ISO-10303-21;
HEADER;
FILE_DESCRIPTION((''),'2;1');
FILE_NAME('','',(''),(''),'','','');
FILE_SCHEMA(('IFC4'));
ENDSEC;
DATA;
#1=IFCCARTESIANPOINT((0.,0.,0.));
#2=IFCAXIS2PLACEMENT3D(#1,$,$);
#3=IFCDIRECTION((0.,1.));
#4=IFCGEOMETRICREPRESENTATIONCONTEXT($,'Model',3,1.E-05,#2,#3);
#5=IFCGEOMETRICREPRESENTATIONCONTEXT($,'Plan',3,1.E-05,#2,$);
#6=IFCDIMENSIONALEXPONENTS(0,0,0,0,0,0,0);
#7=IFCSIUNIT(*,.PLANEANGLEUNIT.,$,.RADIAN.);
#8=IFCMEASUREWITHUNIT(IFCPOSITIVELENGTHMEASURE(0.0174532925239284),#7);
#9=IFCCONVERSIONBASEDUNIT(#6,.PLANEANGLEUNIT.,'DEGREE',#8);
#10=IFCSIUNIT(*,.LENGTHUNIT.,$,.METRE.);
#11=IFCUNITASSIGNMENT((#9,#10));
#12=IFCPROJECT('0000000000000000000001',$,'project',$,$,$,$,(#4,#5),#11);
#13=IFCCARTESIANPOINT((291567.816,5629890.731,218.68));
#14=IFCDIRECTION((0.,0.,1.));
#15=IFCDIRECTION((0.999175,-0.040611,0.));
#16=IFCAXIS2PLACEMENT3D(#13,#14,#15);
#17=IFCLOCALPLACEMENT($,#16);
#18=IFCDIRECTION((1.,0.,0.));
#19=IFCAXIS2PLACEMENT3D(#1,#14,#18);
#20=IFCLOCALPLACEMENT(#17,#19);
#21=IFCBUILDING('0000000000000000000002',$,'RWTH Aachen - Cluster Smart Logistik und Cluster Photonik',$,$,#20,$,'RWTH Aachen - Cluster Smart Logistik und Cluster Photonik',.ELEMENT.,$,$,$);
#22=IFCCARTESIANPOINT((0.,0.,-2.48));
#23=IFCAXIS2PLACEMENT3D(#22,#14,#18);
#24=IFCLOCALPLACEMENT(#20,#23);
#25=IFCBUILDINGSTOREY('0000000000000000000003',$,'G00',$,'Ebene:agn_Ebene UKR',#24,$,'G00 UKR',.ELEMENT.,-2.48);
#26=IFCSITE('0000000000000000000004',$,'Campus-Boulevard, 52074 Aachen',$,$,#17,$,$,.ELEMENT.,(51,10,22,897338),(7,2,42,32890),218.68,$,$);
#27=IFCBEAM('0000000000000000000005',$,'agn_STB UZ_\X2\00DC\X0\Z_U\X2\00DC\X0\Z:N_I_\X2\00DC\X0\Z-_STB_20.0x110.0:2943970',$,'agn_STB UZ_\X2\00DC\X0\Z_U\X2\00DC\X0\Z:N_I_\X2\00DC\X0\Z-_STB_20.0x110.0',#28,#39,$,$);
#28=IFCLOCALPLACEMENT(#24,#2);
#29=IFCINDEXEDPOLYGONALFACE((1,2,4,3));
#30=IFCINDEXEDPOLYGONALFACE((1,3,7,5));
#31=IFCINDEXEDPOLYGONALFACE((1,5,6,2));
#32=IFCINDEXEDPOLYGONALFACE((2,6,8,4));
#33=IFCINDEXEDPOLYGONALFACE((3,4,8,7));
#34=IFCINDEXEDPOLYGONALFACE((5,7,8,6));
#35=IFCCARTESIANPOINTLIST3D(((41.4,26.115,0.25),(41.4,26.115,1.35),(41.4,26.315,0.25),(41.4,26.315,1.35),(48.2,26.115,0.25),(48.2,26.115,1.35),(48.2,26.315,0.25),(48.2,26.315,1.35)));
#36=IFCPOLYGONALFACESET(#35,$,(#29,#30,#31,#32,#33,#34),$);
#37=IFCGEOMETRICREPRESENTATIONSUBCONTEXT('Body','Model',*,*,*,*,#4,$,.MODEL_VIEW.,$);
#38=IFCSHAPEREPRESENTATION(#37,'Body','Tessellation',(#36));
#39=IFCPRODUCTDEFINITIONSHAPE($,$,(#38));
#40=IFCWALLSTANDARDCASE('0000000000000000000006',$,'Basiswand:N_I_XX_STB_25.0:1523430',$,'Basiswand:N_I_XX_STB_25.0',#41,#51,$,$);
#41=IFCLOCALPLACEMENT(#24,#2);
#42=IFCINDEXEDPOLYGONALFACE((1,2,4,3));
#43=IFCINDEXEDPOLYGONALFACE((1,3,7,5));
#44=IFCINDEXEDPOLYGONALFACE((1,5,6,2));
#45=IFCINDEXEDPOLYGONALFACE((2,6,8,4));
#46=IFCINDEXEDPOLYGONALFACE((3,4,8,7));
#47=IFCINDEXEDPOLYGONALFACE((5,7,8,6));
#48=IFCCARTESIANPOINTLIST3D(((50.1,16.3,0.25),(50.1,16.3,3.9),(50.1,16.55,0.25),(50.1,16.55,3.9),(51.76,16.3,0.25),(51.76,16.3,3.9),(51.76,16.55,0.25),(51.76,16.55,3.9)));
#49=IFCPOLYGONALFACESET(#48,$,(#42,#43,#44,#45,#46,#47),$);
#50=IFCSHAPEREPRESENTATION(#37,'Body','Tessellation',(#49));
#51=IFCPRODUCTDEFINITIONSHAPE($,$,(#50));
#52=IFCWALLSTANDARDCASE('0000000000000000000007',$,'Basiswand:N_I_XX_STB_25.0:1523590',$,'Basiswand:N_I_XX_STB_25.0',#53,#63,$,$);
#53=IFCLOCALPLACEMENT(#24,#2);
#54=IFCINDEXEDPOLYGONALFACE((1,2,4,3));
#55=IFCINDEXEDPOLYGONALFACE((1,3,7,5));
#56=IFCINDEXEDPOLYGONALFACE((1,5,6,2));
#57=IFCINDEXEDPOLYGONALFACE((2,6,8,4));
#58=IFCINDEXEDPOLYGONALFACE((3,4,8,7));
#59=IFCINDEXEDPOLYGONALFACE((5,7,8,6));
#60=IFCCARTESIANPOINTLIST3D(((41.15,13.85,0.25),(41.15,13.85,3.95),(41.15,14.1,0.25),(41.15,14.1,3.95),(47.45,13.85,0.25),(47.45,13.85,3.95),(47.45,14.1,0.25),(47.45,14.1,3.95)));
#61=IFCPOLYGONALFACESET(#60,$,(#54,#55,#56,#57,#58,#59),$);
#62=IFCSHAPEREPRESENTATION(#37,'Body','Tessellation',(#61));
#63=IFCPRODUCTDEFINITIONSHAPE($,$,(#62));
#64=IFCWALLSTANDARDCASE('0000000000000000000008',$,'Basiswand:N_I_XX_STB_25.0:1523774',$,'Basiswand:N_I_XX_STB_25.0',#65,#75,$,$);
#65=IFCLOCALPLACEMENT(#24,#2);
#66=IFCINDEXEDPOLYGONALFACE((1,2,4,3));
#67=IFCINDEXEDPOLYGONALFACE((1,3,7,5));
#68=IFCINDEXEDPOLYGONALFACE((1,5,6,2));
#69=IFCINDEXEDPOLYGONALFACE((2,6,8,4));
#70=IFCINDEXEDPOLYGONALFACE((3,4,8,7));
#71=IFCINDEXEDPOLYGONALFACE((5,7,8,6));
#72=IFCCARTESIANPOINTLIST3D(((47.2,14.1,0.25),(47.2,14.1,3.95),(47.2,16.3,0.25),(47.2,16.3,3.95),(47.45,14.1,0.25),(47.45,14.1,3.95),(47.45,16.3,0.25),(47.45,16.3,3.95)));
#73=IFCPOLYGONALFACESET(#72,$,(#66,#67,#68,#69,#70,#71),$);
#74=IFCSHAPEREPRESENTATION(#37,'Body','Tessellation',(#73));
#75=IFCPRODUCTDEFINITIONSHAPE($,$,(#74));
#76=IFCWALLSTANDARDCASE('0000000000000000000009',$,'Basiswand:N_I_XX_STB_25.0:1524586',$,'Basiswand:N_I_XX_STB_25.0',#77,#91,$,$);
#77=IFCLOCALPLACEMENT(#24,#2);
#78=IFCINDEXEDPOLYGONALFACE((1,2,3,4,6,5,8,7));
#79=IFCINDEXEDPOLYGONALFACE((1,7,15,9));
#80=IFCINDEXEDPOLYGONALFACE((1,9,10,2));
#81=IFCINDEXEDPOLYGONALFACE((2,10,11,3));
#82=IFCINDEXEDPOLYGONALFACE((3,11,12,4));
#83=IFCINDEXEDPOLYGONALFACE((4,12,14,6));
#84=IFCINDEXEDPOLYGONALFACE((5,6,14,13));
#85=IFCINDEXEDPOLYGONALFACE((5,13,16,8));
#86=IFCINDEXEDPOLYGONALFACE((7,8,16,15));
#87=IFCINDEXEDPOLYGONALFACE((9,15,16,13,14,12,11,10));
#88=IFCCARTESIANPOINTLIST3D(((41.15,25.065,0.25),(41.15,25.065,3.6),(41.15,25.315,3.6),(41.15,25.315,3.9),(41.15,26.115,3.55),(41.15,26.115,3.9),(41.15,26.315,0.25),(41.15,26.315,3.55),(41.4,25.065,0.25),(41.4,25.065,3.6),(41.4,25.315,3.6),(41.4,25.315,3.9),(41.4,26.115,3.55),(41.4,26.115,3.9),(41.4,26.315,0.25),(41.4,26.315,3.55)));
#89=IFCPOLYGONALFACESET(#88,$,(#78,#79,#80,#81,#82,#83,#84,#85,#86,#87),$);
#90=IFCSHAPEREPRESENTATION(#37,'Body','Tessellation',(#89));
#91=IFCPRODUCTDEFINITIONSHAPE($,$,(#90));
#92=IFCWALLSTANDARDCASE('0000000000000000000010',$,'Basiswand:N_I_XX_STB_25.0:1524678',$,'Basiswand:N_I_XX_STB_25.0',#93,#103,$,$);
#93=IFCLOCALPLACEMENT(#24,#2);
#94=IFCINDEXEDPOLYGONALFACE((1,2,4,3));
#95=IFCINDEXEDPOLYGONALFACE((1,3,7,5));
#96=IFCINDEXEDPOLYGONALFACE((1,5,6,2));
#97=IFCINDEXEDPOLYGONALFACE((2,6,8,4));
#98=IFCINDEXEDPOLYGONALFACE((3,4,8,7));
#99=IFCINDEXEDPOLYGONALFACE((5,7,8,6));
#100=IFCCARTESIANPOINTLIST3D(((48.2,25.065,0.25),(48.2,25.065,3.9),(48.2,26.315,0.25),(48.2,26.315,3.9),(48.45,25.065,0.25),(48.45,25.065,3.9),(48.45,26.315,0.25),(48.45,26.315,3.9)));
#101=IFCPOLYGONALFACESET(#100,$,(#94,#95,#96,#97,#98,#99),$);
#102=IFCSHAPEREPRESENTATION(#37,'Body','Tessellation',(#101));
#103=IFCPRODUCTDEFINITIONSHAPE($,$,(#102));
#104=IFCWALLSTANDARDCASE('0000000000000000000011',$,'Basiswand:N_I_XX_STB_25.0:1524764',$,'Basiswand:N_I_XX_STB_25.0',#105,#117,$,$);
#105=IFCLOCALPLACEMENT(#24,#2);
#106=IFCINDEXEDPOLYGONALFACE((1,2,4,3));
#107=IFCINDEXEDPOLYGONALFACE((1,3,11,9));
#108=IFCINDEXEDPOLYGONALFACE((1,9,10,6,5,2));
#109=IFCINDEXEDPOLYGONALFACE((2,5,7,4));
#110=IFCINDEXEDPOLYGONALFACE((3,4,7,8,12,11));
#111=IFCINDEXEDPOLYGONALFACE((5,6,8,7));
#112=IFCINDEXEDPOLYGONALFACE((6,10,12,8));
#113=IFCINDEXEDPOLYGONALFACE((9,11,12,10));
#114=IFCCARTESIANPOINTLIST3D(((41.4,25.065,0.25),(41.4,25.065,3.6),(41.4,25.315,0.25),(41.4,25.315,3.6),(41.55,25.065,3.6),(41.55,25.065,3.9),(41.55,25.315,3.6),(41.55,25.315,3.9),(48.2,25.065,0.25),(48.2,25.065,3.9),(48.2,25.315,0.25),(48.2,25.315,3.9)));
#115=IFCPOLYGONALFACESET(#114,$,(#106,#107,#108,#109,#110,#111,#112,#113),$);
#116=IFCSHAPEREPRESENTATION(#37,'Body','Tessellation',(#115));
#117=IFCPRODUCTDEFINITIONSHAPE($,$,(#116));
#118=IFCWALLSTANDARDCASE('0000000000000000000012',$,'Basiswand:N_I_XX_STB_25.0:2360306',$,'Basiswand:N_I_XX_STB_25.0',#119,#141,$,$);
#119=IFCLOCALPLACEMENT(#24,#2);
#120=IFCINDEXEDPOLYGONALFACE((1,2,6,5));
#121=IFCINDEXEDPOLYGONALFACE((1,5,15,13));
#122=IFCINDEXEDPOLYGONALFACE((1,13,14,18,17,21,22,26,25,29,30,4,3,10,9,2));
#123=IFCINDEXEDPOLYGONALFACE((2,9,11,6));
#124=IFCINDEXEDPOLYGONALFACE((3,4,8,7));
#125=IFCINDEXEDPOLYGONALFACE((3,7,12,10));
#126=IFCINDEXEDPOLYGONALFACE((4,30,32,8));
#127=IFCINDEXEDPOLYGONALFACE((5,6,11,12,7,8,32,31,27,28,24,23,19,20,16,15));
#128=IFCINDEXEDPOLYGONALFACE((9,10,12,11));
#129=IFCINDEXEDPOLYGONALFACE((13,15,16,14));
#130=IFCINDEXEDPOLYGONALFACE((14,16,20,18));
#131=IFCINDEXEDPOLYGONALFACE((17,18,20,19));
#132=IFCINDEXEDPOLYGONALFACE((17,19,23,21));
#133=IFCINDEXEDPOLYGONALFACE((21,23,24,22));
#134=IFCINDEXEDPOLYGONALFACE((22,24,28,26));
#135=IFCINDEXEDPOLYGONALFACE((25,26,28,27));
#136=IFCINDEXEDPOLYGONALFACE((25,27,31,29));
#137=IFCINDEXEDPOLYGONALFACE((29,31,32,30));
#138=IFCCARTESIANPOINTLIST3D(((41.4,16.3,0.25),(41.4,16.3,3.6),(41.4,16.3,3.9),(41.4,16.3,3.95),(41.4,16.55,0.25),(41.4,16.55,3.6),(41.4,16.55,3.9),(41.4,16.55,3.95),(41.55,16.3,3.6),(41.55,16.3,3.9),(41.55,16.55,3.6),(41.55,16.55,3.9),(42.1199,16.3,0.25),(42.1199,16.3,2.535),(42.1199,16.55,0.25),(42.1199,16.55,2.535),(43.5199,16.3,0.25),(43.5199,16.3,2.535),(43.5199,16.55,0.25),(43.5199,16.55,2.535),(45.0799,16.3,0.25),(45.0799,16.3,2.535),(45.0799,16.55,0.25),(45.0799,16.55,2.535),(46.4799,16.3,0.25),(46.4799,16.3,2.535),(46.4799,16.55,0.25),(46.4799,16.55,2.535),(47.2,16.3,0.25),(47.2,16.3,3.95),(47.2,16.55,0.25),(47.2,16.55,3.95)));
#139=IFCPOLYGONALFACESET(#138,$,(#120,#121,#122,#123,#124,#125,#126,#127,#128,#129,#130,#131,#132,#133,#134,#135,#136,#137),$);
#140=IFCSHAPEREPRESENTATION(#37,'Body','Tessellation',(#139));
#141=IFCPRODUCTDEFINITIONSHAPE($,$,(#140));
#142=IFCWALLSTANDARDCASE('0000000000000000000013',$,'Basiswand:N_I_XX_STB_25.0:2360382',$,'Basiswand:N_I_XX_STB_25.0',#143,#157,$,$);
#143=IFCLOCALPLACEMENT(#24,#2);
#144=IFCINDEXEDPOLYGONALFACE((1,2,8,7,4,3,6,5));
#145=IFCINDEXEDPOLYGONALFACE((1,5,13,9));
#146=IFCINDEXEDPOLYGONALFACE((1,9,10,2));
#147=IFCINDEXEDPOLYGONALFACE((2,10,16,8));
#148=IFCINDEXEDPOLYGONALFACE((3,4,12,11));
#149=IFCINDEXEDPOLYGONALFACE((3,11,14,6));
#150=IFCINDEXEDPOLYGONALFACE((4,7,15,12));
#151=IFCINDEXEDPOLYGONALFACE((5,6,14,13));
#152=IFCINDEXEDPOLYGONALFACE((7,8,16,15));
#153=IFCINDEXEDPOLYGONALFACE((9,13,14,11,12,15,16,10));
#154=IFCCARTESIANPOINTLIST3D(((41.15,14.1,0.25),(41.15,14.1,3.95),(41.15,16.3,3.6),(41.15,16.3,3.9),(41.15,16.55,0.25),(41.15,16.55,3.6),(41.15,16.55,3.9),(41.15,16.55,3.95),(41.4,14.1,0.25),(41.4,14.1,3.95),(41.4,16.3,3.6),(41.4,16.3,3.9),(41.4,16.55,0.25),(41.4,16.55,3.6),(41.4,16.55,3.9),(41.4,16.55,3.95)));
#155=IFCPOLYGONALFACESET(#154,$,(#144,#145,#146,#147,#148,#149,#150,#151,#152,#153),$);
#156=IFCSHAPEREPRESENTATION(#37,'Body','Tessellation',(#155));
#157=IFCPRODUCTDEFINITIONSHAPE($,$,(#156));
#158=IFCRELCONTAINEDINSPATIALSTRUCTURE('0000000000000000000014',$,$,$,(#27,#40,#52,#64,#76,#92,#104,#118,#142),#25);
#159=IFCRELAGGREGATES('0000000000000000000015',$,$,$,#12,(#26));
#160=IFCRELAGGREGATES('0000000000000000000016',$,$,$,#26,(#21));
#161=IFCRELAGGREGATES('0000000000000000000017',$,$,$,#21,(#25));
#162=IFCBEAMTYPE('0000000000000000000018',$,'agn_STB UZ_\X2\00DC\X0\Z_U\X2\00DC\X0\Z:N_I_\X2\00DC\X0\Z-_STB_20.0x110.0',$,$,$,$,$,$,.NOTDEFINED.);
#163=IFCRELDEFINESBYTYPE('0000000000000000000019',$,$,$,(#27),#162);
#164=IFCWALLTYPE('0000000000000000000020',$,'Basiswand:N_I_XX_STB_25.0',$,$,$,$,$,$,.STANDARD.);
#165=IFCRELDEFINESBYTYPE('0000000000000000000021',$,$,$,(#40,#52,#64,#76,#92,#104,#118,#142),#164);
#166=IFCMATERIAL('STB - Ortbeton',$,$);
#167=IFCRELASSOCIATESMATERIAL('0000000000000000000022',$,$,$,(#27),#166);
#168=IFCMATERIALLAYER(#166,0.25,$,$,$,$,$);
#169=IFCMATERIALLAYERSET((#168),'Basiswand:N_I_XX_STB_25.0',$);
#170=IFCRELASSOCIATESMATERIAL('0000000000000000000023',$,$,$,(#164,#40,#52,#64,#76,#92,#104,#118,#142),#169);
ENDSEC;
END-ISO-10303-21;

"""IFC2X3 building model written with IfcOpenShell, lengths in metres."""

from ifc_helpers import new_model, entity, si_unit, converted_unit, direction, frame, frame_2d, origin, origin_with_axes, place, context, subcontext, project, spatial, polyline, rectangle, extrude, clip, bounded_halfspace, material, layer, layer_set, layer_usage, type_object, element, save


model = new_model("IFC2X3")

# Units and contexts
model_context = context("Model", 3, precision=1e-05, world=origin(), true_north=direction((0.0, 1.0)))
plan_context = context("Plan", 3, precision=1e-05, world=origin())
body_context = subcontext(model_context, "Body", "Model", "MODEL_VIEW")
ifc_project = project(units=[converted_unit("PLANEANGLEUNIT", "DEGREE", entity("IfcPositiveLengthMeasure", 0.0174532925239284), si_unit("PLANEANGLEUNIT", "RADIAN"), dimensions=[0, 0, 0, 0, 0, 0, 0]), si_unit("LENGTHUNIT", "METRE")], contexts=[model_context, plan_context])

# Site, building, storey
site_placement = place(None, frame((291567.816, 5629890.731, 218.68), z_axis=(0.0, 0.0, 1.0), x_axis=(0.999175, -0.040611, 0.0)))
site = spatial("IfcSite", under=ifc_project, at=site_placement, Name="Campus-Boulevard, 52074 Aachen", CompositionType="ELEMENT", RefLatitude=(51, 10, 22, 897338), RefLongitude=(7, 2, 42, 32890), RefElevation=218.68)
building_placement = place(site_placement, origin_with_axes())
building = spatial("IfcBuilding", under=site, at=building_placement, Name="RWTH Aachen - Cluster Smart Logistik und Cluster Photonik", LongName="RWTH Aachen - Cluster Smart Logistik und Cluster Photonik", CompositionType="ELEMENT")
storey_placement = place(building_placement, frame((0.0, 0.0, -2.48), z_axis=(0.0, 0.0, 1.0), x_axis=(1.0, 0.0, 0.0)))
storey = spatial("IfcBuildingStorey", under=building, at=storey_placement, Name="G00", ObjectType="Ebene:agn_Ebene UKR", LongName="G00 UKR", CompositionType="ELEMENT", Elevation=-2.48)

# Beam
ifc_material_1 = material(Name="STB - Ortbeton")
beam_type_1 = type_object("IfcBeamType", Name="agn_STB UZ_ÜZ_UÜZ:N_I_ÜZ-_STB_20.0x110.0", PredefinedType="NOTDEFINED")
beam_1_placement = place(storey_placement, frame((48.325, 26.215, 0.25), z_axis=(0.0, 0.0, 1.0), x_axis=(-1.0, 0.0, 0.0)))
element("IfcBeam", 1, at=beam_1_placement, inside=storey, type_object=beam_type_1, material=ifc_material_1, Name="agn_STB UZ_ÜZ_UÜZ:N_I_ÜZ-_STB_20.0x110.0:2943970", ObjectType="agn_STB UZ_ÜZ_UÜZ:N_I_ÜZ-_STB_20.0x110.0", context=body_context, shape_type="SweptSolid", body=[
    extrude(rectangle(XDim=1.1, YDim=0.2, at=frame_2d((0.0, 0.0), x_axis=(1.0, 0.0))), frame((0.125, 0.0, 0.55), z_axis=(1.0, 0.0, 0.0), x_axis=(0.0, 0.0, -1.0)), (0.0, 0.0, 1.0), 6.8),
])

# Walls
ifc_layer_1 = layer(ifc_material_1, 0.25)
ifc_layer_set_1 = layer_set([ifc_layer_1], Name="Basiswand:N_I_XX_STB_25.0")
ifc_layer_usage_1 = layer_usage(ifc_layer_set_1, "AXIS2", "NEGATIVE", 0.125)
wall_type_1 = type_object("IfcWallType", Name="Basiswand:N_I_XX_STB_25.0", PredefinedType="STANDARD", material=ifc_layer_set_1)
wall_1_placement = place(storey_placement, frame((51.76, 16.425, 0.25), z_axis=(0.0, 0.0, 1.0), x_axis=(-1.0, 0.0, 0.0)))
element("IfcWallStandardCase", 2, at=wall_1_placement, inside=storey, type_object=wall_type_1, material=ifc_layer_usage_1, Name="Basiswand:N_I_XX_STB_25.0:1523430", ObjectType="Basiswand:N_I_XX_STB_25.0", context=body_context, shape_type="SweptSolid", body=[
    extrude(rectangle(XDim=1.66, YDim=0.25, at=frame_2d((0.83, 0.0), x_axis=(-1.0, 0.0))), origin(), (0.0, 0.0, 1.0), 3.65),
])
ifc_layer_usage_2 = layer_usage(ifc_layer_set_1, "AXIS2", "NEGATIVE", 0.125)
wall_2_placement = place(storey_placement, frame((47.45, 13.975, 0.25), z_axis=(0.0, 0.0, 1.0), x_axis=(-1.0, 0.0, 0.0)))
element("IfcWallStandardCase", 3, at=wall_2_placement, inside=storey, type_object=wall_type_1, material=ifc_layer_usage_2, Name="Basiswand:N_I_XX_STB_25.0:1523590", ObjectType="Basiswand:N_I_XX_STB_25.0", context=body_context, shape_type="SweptSolid", body=[
    extrude(rectangle(XDim=6.3, YDim=0.25, at=frame_2d((3.15, 0.0), x_axis=(-1.0, 0.0))), origin(), (0.0, 0.0, 1.0), 3.7),
])
ifc_layer_usage_3 = layer_usage(ifc_layer_set_1, "AXIS2", "NEGATIVE", 0.125)
wall_3_placement = place(storey_placement, frame((47.325, 14.1, 0.25), z_axis=(0.0, 0.0, 1.0), x_axis=(0.0, 1.0, 0.0)))
element("IfcWallStandardCase", 4, at=wall_3_placement, inside=storey, type_object=wall_type_1, material=ifc_layer_usage_3, Name="Basiswand:N_I_XX_STB_25.0:1523774", ObjectType="Basiswand:N_I_XX_STB_25.0", context=body_context, shape_type="SweptSolid", body=[
    extrude(rectangle(XDim=2.2, YDim=0.25, at=frame_2d((1.1, 0.0), x_axis=(-1.0, 0.0))), origin(), (0.0, 0.0, 1.0), 3.7),
])
ifc_layer_usage_4 = layer_usage(ifc_layer_set_1, "AXIS2", "NEGATIVE", 0.125)
wall_4_placement = place(storey_placement, frame((41.275, 26.315, 0.25), z_axis=(0.0, 0.0, 1.0), x_axis=(0.0, -1.0, 0.0)))
element("IfcWallStandardCase", 5, at=wall_4_placement, inside=storey, type_object=wall_type_1, material=ifc_layer_usage_4, Name="Basiswand:N_I_XX_STB_25.0:1524586", ObjectType="Basiswand:N_I_XX_STB_25.0", context=body_context, shape_type="Clipping", body=[
    clip(clip(clip(clip(extrude(rectangle(XDim=1.25, YDim=0.25, at=frame_2d((0.625, 0.0), x_axis=(-1.0, 0.0))), origin(), (0.0, 0.0, 1.0), 3.65), bounded_halfspace(frame((1.0, 0.125, 3.35), z_axis=(0.0, 0.0, -1.0), x_axis=(-1.0, 0.0, 0.0)), True, frame((1.0, 0.125, 3.35), z_axis=(0.0, 0.0, -1.0), x_axis=(-1.0, 0.0, 0.0)), polyline([(0.0, 0.0), (-0.25, 0.0), (-0.25, -0.25), (0.0, -0.25), (0.0, 0.0)]))), bounded_halfspace(frame((1.0, -0.125, 3.35), z_axis=(1.0, 0.0, 0.0), x_axis=(0.0, 1.0, 0.0)), False, frame((1.0, -0.125, 3.35), z_axis=(1.0, 0.0, 0.0), x_axis=(0.0, 1.0, 0.0)), polyline([(0.0, 0.0), (0.25, 0.0), (0.25, 0.3), (0.0, 0.3), (0.0, 0.0)]))), bounded_halfspace(frame((0.2, 0.125, 3.3), z_axis=(1.0, 0.0, 0.0), x_axis=(0.0, 0.0, 1.0)), True, frame((0.2, 0.125, 3.3), z_axis=(1.0, 0.0, 0.0), x_axis=(0.0, 0.0, 1.0)), polyline([(0.0, 0.0), (0.35, 0.0), (0.35, 0.25), (0.0, 0.25), (0.0, 0.0)]))), bounded_halfspace(frame((0.2, -0.125, 3.3), z_axis=(0.0, 0.0, 1.0), x_axis=(0.0, -1.0, 0.0)), False, frame((0.2, -0.125, 3.3), z_axis=(0.0, 0.0, 1.0), x_axis=(0.0, -1.0, 0.0)), polyline([(0.0, 0.0), (-0.25, 0.0), (-0.25, -0.2), (0.0, -0.2), (0.0, 0.0)]))),
])
ifc_layer_usage_5 = layer_usage(ifc_layer_set_1, "AXIS2", "NEGATIVE", 0.125)
wall_5_placement = place(storey_placement, frame((48.325, 26.315, 0.25), z_axis=(0.0, 0.0, 1.0), x_axis=(0.0, -1.0, 0.0)))
element("IfcWallStandardCase", 6, at=wall_5_placement, inside=storey, type_object=wall_type_1, material=ifc_layer_usage_5, Name="Basiswand:N_I_XX_STB_25.0:1524678", ObjectType="Basiswand:N_I_XX_STB_25.0", context=body_context, shape_type="SweptSolid", body=[
    extrude(rectangle(XDim=1.25, YDim=0.25, at=frame_2d((0.625, 0.0), x_axis=(-1.0, 0.0))), origin(), (0.0, 0.0, 1.0), 3.65),
])
ifc_layer_usage_6 = layer_usage(ifc_layer_set_1, "AXIS2", "NEGATIVE", 0.125)
wall_6_placement = place(storey_placement, frame((41.4, 25.19, 0.25), z_axis=(0.0, 0.0, 1.0), x_axis=(1.0, 0.0, 0.0)))
element("IfcWallStandardCase", 7, at=wall_6_placement, inside=storey, type_object=wall_type_1, material=ifc_layer_usage_6, Name="Basiswand:N_I_XX_STB_25.0:1524764", ObjectType="Basiswand:N_I_XX_STB_25.0", context=body_context, shape_type="Clipping", body=[
    clip(clip(extrude(rectangle(XDim=6.8, YDim=0.25, at=frame_2d((3.4, 0.0), x_axis=(-1.0, 0.0))), origin(), (0.0, 0.0, 1.0), 3.65), bounded_halfspace(frame((0.15, -0.125, 3.35), z_axis=(0.0, 0.0, -1.0), x_axis=(0.0, 1.0, 0.0)), True, frame((0.15, -0.125, 3.35), z_axis=(0.0, 0.0, -1.0), x_axis=(0.0, 1.0, 0.0)), polyline([(0.0, 0.0), (0.0, -0.15), (0.25, -0.15), (0.25, 0.0), (0.0, 0.0)]))), bounded_halfspace(frame((0.15, 0.125, 3.35), z_axis=(1.0, 0.0, 0.0), x_axis=(0.0, 1.0, 0.0)), True, frame((0.15, 0.125, 3.35), z_axis=(1.0, 0.0, 0.0), x_axis=(0.0, 1.0, 0.0)), polyline([(0.0, 0.0), (0.0, 0.3), (-0.25, 0.3), (-0.25, 0.0), (0.0, 0.0)]))),
])

# Wall, openings
ifc_layer_usage_7 = layer_usage(ifc_layer_set_1, "AXIS2", "NEGATIVE", 0.125)
wall_7_placement = place(storey_placement, frame((47.2, 16.425, 0.25), z_axis=(0.0, 0.0, 1.0), x_axis=(-1.0, 0.0, 0.0)))
wall_7 = element("IfcWallStandardCase", 8, at=wall_7_placement, inside=storey, type_object=wall_type_1, material=ifc_layer_usage_7, Name="Basiswand:N_I_XX_STB_25.0:2360306", ObjectType="Basiswand:N_I_XX_STB_25.0", context=body_context, shape_type="Clipping", body=[
    clip(extrude(rectangle(XDim=5.8, YDim=0.25, at=frame_2d((2.9, 0.0), x_axis=(-1.0, 0.0))), origin(), (0.0, 0.0, 1.0), 3.7), bounded_halfspace(frame((5.65, 0.125, 3.65), z_axis=(-1.0, 0.0, 0.0), x_axis=(0.0, -1.0, 0.0)), True, frame((5.65, 0.125, 3.65), z_axis=(-1.0, 0.0, 0.0), x_axis=(0.0, -1.0, 0.0)), polyline([(0.0, 0.0), (0.0, -0.3), (0.25, -0.3), (0.25, 0.0), (0.0, 0.0)]))),
])
opening_1_placement = place(wall_7_placement, frame((0.7201, -0.125, 0.0), z_axis=(0.0, 0.0, 1.0), x_axis=(1.0, 0.0, 0.0)))
element("IfcOpeningElement", 9, at=opening_1_placement, cuts=wall_7, ObjectType="Opening", context=body_context, shape_type="SweptSolid", body=[
    extrude(rectangle(XDim=2.285, YDim=1.4, at=frame_2d((1.1425, 0.7), x_axis=(1.0, 0.0))), frame((0.0, 0.0, 0.0), z_axis=(0.0, 1.0, 0.0), x_axis=(0.0, 0.0, 1.0)), (0.0, 0.0, 1.0), 0.25),
])
opening_2_placement = place(wall_7_placement, frame((3.6801, -0.125, 0.0), z_axis=(0.0, 0.0, 1.0), x_axis=(1.0, 0.0, 0.0)))
element("IfcOpeningElement", 10, at=opening_2_placement, cuts=wall_7, ObjectType="Opening", context=body_context, shape_type="SweptSolid", body=[
    extrude(rectangle(XDim=2.285, YDim=1.4, at=frame_2d((1.1425, 0.7), x_axis=(1.0, 0.0))), frame((0.0, 0.0, 0.0), z_axis=(0.0, 1.0, 0.0), x_axis=(0.0, 0.0, 1.0)), (0.0, 0.0, 1.0), 0.25),
])

# Wall
ifc_layer_usage_8 = layer_usage(ifc_layer_set_1, "AXIS2", "POSITIVE", -0.125)
wall_8_placement = place(storey_placement, frame((41.275, 14.1, 0.25), z_axis=(0.0, 0.0, 1.0), x_axis=(0.0, 1.0, 0.0)))
element("IfcWallStandardCase", 11, at=wall_8_placement, inside=storey, type_object=wall_type_1, material=ifc_layer_usage_8, Name="Basiswand:N_I_XX_STB_25.0:2360382", ObjectType="Basiswand:N_I_XX_STB_25.0", context=body_context, shape_type="Clipping", body=[
    clip(extrude(rectangle(XDim=2.45, YDim=0.25, at=frame_2d((1.225, 0.0), x_axis=(-1.0, 0.0))), origin(), (0.0, 0.0, 1.0), 3.7), bounded_halfspace(frame((2.2, -0.125, 3.35), z_axis=(1.0, 0.0, 0.0), x_axis=(0.0, 0.0, 1.0)), False, frame((2.2, -0.125, 3.35), z_axis=(1.0, 0.0, 0.0), x_axis=(0.0, 0.0, 1.0)), polyline([(0.0, 0.0), (0.0, -0.25), (0.3, -0.25), (0.3, 0.0), (0.0, 0.0)]))),
])

save(model, "model.ifc")
